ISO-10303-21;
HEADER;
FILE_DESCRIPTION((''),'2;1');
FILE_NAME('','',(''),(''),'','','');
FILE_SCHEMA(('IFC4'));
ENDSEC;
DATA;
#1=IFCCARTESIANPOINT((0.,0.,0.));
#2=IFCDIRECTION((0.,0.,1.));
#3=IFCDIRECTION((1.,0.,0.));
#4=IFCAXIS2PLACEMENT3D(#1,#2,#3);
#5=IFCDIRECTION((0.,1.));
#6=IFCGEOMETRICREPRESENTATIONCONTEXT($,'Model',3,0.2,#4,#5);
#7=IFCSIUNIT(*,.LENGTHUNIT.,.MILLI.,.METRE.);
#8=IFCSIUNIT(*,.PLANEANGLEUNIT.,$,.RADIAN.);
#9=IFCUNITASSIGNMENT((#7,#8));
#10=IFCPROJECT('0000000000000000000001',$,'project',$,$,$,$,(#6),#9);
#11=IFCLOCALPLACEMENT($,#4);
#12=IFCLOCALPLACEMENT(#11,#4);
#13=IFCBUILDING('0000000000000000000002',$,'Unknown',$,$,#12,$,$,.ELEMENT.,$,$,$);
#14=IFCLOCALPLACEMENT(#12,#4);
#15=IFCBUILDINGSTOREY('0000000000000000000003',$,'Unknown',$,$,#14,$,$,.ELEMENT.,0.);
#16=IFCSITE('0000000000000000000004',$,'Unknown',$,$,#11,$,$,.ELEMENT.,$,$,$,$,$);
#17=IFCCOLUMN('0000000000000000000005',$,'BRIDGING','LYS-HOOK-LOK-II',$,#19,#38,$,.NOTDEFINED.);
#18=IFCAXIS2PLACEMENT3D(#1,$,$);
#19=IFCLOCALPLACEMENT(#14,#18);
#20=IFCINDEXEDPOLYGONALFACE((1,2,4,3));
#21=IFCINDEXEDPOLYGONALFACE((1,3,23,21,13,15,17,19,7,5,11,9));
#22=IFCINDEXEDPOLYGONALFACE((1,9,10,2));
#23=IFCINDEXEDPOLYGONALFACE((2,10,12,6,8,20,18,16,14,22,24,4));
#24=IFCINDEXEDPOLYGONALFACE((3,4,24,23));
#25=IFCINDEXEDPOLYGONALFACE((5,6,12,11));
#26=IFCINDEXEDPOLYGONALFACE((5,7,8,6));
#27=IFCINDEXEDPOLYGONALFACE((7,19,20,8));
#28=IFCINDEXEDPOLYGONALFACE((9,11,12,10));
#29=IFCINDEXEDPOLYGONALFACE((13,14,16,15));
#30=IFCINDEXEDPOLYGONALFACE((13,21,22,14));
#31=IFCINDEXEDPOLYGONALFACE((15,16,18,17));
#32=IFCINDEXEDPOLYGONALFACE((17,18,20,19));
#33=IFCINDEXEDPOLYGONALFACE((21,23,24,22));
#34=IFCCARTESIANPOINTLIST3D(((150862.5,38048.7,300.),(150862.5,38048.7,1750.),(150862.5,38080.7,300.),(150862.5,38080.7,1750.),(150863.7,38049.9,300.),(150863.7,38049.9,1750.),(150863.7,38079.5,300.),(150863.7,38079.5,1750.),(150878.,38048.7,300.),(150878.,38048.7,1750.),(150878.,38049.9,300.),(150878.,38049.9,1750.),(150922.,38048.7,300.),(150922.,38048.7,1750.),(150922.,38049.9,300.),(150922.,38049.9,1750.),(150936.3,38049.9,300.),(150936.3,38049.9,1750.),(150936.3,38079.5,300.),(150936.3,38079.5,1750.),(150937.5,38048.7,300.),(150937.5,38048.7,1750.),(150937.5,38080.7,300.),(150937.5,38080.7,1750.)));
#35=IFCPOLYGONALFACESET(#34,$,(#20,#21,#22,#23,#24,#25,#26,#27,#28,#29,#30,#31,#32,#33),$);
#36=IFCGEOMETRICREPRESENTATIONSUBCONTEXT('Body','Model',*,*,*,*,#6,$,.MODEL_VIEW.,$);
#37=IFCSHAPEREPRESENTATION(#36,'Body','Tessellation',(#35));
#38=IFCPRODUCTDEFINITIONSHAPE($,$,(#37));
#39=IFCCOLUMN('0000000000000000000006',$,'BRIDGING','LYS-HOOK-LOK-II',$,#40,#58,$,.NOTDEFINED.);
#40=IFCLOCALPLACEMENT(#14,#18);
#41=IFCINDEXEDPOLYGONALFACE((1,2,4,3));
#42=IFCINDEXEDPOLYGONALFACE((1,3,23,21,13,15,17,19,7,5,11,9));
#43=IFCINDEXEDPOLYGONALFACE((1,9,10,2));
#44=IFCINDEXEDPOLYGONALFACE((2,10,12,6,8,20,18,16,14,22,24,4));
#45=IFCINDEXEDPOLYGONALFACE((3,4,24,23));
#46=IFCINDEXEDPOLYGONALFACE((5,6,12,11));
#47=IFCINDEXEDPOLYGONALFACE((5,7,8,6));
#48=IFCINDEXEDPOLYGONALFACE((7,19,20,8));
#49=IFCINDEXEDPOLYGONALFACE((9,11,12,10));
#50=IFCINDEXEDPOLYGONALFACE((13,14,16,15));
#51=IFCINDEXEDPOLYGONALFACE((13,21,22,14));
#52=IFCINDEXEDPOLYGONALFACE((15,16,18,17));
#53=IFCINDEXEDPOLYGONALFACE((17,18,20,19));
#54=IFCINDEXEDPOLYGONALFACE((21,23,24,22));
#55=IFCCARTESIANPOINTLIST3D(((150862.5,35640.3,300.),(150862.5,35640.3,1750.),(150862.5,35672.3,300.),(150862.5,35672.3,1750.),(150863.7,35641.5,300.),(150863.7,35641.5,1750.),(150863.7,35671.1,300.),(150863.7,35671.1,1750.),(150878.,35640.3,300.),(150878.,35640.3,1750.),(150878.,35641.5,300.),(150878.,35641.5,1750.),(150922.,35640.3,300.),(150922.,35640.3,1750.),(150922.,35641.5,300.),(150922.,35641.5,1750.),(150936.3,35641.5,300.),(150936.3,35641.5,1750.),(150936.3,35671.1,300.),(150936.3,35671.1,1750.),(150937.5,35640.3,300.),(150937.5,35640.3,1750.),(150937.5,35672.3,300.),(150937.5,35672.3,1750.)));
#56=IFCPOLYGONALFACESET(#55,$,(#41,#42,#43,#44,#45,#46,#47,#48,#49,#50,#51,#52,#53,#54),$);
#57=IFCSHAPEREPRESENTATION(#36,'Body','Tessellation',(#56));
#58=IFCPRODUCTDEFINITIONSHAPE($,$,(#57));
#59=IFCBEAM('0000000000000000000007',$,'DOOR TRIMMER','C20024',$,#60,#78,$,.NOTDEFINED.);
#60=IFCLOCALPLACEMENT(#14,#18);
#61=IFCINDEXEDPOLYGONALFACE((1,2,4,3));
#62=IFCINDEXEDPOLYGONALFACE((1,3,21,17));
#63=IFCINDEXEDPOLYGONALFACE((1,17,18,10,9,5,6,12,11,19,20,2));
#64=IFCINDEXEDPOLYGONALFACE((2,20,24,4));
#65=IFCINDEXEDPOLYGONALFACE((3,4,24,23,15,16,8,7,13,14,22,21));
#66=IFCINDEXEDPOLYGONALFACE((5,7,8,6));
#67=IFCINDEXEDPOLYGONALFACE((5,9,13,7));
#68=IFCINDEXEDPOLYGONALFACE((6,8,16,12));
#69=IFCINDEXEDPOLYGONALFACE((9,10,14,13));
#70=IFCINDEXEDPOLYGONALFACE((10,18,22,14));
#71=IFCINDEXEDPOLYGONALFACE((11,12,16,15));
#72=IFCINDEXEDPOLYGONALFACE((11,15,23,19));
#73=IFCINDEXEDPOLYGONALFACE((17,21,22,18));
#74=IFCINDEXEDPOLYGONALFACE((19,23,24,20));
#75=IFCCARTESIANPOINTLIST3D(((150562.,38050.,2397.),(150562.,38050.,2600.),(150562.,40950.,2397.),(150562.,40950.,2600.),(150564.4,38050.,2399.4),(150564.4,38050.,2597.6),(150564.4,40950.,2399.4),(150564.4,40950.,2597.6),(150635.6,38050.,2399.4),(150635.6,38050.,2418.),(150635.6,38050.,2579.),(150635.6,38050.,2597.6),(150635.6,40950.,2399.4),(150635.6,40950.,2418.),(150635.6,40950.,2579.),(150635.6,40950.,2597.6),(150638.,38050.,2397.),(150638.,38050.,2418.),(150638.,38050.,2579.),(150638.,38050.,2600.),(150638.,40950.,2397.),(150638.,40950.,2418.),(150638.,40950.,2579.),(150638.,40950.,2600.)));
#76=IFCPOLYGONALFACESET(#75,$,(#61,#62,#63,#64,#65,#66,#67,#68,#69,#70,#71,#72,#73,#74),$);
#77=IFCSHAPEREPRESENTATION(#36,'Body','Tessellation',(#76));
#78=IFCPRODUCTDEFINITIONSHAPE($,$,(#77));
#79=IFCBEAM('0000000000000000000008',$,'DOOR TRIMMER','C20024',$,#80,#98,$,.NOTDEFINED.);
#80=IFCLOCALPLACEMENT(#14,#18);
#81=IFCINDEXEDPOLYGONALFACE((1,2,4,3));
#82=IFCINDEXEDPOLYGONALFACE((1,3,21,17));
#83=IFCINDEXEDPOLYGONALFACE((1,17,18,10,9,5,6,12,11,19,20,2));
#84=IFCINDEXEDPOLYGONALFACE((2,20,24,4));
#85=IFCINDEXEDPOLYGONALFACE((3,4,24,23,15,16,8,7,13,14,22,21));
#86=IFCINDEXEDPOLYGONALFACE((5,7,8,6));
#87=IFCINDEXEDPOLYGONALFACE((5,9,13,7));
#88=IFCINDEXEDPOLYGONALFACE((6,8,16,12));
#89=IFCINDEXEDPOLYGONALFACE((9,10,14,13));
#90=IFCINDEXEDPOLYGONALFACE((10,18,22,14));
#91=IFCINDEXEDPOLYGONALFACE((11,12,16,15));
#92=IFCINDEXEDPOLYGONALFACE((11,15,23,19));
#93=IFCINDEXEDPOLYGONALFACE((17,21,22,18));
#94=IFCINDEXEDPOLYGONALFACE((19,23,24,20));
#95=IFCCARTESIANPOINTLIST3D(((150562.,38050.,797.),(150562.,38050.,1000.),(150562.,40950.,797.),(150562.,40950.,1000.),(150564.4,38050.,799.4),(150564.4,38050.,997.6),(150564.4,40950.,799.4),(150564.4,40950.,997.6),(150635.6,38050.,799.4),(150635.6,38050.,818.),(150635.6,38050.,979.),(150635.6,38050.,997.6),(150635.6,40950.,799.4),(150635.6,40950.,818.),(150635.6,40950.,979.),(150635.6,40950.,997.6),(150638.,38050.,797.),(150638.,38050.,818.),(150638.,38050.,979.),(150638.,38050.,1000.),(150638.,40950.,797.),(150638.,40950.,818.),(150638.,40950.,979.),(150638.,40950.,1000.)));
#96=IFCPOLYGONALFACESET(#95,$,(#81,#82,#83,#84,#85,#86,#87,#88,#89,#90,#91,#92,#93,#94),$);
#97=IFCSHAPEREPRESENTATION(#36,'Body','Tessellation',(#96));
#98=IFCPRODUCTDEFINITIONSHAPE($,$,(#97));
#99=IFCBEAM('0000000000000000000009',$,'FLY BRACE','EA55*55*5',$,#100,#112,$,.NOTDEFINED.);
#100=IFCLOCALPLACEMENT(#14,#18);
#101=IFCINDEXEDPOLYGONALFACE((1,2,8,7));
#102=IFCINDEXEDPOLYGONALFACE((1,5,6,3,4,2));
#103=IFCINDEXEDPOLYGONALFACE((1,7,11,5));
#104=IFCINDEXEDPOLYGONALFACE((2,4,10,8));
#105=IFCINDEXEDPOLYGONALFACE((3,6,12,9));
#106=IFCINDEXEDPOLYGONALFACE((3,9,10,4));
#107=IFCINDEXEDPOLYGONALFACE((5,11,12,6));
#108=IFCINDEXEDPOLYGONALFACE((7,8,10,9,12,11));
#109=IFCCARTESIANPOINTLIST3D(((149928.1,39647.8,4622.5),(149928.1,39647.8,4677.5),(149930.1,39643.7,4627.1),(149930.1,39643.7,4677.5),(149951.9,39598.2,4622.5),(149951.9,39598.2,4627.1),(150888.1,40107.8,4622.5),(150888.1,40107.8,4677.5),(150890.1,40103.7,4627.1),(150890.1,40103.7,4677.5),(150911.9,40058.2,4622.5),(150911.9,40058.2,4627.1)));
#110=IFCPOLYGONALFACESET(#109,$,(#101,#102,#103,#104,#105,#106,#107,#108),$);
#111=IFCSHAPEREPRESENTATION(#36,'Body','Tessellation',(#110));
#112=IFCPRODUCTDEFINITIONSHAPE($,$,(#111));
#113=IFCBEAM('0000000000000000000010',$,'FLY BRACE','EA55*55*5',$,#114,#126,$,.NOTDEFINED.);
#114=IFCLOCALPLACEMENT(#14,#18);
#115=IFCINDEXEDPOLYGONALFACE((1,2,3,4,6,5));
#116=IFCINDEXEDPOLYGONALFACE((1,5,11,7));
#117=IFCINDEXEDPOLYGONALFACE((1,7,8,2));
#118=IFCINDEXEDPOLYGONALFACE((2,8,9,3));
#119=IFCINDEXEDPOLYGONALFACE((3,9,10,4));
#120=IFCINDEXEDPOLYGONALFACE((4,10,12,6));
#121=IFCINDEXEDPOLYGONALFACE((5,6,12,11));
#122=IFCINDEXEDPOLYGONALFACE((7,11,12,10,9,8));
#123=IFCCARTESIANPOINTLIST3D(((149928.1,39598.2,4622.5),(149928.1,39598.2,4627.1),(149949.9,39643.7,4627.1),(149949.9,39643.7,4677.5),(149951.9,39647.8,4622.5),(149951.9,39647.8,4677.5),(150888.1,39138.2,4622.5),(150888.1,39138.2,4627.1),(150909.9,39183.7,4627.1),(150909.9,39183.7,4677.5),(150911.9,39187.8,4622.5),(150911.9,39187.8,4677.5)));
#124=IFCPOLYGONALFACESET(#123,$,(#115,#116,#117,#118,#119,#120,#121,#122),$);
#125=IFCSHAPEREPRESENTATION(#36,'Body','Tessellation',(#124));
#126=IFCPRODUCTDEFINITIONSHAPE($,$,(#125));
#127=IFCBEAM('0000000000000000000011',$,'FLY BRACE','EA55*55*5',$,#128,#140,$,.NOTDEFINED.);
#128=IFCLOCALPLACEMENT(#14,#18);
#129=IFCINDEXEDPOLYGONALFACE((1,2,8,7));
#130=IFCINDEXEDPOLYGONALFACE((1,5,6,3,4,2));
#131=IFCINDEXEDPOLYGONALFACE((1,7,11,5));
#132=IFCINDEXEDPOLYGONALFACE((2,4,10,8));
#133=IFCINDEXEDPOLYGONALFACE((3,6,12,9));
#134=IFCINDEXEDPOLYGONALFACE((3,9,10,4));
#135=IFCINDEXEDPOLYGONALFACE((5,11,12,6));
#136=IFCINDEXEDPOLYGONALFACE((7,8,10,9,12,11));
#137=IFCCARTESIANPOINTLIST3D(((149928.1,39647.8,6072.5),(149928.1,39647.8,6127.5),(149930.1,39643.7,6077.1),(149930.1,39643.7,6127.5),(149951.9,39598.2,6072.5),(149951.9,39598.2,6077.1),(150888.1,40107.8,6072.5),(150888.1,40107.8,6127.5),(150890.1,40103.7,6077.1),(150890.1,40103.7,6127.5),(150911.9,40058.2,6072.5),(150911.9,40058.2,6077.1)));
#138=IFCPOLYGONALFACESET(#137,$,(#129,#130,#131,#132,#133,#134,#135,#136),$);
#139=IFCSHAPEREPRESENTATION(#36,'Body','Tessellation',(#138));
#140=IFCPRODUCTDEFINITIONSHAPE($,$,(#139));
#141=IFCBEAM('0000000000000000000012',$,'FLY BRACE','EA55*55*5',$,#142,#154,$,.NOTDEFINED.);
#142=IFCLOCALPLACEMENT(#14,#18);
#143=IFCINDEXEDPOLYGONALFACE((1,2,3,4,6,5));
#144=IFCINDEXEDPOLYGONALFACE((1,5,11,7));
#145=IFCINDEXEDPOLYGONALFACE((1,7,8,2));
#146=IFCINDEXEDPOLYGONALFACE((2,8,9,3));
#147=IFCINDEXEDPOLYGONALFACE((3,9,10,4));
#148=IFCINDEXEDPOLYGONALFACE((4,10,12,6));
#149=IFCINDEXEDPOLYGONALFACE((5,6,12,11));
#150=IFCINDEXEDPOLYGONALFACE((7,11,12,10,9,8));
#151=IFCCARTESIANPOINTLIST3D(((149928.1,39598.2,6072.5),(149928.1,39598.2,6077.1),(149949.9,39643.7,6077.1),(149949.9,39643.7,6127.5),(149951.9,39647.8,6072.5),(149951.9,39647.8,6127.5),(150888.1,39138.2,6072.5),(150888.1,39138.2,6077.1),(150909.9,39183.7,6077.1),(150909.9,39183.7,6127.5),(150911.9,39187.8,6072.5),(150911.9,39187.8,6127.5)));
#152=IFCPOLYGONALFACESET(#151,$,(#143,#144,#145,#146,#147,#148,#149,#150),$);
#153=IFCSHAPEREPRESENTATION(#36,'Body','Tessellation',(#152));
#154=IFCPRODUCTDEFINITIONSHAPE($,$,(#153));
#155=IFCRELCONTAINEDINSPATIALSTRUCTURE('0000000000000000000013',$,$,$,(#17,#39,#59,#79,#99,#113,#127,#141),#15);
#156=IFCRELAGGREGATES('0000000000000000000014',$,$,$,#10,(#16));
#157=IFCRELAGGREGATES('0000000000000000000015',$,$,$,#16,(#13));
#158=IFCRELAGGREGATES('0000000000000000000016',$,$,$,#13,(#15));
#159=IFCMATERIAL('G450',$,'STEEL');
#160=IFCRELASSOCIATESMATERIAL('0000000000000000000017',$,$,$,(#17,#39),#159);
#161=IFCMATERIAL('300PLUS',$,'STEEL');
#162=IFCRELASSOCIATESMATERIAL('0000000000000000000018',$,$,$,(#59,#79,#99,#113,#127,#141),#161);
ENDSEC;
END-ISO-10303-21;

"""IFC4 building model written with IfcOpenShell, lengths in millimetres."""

from ifc_helpers import new_model, si_unit, direction, frame, origin_with_axes, place, context, subcontext, project, spatial, line, indexed_curve, outline, extrude, material, element, save


model = new_model("IFC4")

# Units and contexts
model_context = context("Model", 3, precision=0.2, world=origin_with_axes(), true_north=direction((0.0, 1.0)))
body_context = subcontext(model_context, "Body", "Model", "MODEL_VIEW")
ifc_project = project(units=[si_unit("LENGTHUNIT", "METRE", prefix="MILLI"), si_unit("PLANEANGLEUNIT", "RADIAN")], contexts=[model_context])

# Site, building, storey
site_placement = place(None, origin_with_axes())
site = spatial("IfcSite", under=ifc_project, at=site_placement, Name="Unknown", CompositionType="ELEMENT")
building_placement = place(site_placement, origin_with_axes())
building = spatial("IfcBuilding", under=site, at=building_placement, Name="Unknown", CompositionType="ELEMENT")
storey_placement = place(building_placement, origin_with_axes())
storey = spatial("IfcBuildingStorey", under=building, at=storey_placement, Name="Unknown", CompositionType="ELEMENT", Elevation=0.0)

# Columns
ifc_material_1 = material(Name="300PLUS", Category="STEEL")
ifc_material_2 = material(Name="G450", Category="STEEL")
for number, where, z_axis, x_axis, name in (
    (1, (150900.0, 38064.7, 300.0), (0.0, -1.0, 0.0), (0.0, 0.0, 1.0), "BRIDGING"),
    (2, (150900.0, 35656.3, 300.0), (0.0, -1.0, 0.0), (0.0, 0.0, 1.0), "BRIDGING"),
):
    element("IfcColumn", number, at=place(storey_placement, frame(where, z_axis=z_axis, x_axis=x_axis)), inside=storey, material=ifc_material_2, Name=name, Description="LYS-HOOK-LOK-II", PredefinedType="NOTDEFINED", context=body_context, shape_type="SolidModel", body=[
        extrude(outline(indexed_curve([(16.0, -37.5), (16.0, -22.0), (14.8, -22.0), (14.8, -36.3), (-14.8, -36.3), (-14.8, 36.3), (14.8, 36.3), (14.8, 22.0), (16.0, 22.0), (16.0, 37.5), (-16.0, 37.5), (-16.0, -37.5)], segments=[line(1, 2, 3, 4, 5, 6, 7, 8, 9, 10, 11, 12, 1)])), frame((0.0, 0.0, 0.0), z_axis=(-1.0, 0.0, 0.0), x_axis=(0.0, 0.0, 1.0)), (0.0, 0.0, -1.0), 1450.0),
    ])

# Beams
for number, where, z_axis, x_axis, name in (
    (3, (150600.0, 38050.0, 2498.5), (1.0, 0.0, 0.0), (0.0, 1.0, 0.0), "DOOR TRIMMER"),
    (4, (150600.0, 38050.0, 898.5), (1.0, 0.0, 0.0), (0.0, 1.0, 0.0), "DOOR TRIMMER"),
):
    element("IfcBeam", number, at=place(storey_placement, frame(where, z_axis=z_axis, x_axis=x_axis)), inside=storey, material=ifc_material_1, Name=name, Description="C20024", PredefinedType="NOTDEFINED", context=body_context, shape_type="SolidModel", body=[
        extrude(outline(indexed_curve([(38.0, -101.5), (38.0, -80.5), (35.6, -80.5), (35.6, -99.1), (-35.6, -99.1), (-35.6, 99.1), (35.6, 99.1), (35.6, 80.5), (38.0, 80.5), (38.0, 101.5), (-38.0, 101.5), (-38.0, -101.5)], segments=[line(1, 2, 3, 4, 5, 6, 7, 8, 9, 10, 11, 12, 1)])), frame((0.0, 0.0, 0.0), z_axis=(-1.0, 0.0, 0.0), x_axis=(0.0, 0.0, 1.0)), (0.0, 0.0, -1.0), 2900.0),
    ])
for number, where, z_axis, x_axis, name in (
    (5, (150900.0, 40083.0, 4650.0), (0.0, 0.0, 1.0), (-0.901816, -0.43212, 0.0), "FLY BRACE"),
    (6, (150900.0, 39163.0, 4650.0), (0.0, 0.0, 1.0), (-0.901816, 0.43212, 0.0), "FLY BRACE"),
    (7, (150900.0, 40083.0, 6100.0), (0.0, 0.0, 1.0), (-0.901816, -0.43212, 0.0), "FLY BRACE"),
    (8, (150900.0, 39163.0, 6100.0), (0.0, 0.0, 1.0), (-0.901816, 0.43212, 0.0), "FLY BRACE"),
):
    element("IfcBeam", number, at=place(storey_placement, frame(where, z_axis=z_axis, x_axis=x_axis)), inside=storey, material=ifc_material_1, Name=name, Description="EA55*55*5", PredefinedType="NOTDEFINED", context=body_context, shape_type="SolidModel", body=[
        extrude(outline(indexed_curve([(-27.5, -27.5), (27.5, -27.5), (27.5, -22.9), (-22.9, -22.9), (-22.9, 27.5), (-27.5, 27.5)], segments=[line(1, 2, 3, 4, 5, 6, 1)])), frame((0.0, 0.0, 0.0), z_axis=(-1.0, 0.0, 0.0), x_axis=(0.0, 0.0, 1.0)), (0.0, 0.0, -1.0), 1064.5),
    ])

save(model, "model.ifc")
